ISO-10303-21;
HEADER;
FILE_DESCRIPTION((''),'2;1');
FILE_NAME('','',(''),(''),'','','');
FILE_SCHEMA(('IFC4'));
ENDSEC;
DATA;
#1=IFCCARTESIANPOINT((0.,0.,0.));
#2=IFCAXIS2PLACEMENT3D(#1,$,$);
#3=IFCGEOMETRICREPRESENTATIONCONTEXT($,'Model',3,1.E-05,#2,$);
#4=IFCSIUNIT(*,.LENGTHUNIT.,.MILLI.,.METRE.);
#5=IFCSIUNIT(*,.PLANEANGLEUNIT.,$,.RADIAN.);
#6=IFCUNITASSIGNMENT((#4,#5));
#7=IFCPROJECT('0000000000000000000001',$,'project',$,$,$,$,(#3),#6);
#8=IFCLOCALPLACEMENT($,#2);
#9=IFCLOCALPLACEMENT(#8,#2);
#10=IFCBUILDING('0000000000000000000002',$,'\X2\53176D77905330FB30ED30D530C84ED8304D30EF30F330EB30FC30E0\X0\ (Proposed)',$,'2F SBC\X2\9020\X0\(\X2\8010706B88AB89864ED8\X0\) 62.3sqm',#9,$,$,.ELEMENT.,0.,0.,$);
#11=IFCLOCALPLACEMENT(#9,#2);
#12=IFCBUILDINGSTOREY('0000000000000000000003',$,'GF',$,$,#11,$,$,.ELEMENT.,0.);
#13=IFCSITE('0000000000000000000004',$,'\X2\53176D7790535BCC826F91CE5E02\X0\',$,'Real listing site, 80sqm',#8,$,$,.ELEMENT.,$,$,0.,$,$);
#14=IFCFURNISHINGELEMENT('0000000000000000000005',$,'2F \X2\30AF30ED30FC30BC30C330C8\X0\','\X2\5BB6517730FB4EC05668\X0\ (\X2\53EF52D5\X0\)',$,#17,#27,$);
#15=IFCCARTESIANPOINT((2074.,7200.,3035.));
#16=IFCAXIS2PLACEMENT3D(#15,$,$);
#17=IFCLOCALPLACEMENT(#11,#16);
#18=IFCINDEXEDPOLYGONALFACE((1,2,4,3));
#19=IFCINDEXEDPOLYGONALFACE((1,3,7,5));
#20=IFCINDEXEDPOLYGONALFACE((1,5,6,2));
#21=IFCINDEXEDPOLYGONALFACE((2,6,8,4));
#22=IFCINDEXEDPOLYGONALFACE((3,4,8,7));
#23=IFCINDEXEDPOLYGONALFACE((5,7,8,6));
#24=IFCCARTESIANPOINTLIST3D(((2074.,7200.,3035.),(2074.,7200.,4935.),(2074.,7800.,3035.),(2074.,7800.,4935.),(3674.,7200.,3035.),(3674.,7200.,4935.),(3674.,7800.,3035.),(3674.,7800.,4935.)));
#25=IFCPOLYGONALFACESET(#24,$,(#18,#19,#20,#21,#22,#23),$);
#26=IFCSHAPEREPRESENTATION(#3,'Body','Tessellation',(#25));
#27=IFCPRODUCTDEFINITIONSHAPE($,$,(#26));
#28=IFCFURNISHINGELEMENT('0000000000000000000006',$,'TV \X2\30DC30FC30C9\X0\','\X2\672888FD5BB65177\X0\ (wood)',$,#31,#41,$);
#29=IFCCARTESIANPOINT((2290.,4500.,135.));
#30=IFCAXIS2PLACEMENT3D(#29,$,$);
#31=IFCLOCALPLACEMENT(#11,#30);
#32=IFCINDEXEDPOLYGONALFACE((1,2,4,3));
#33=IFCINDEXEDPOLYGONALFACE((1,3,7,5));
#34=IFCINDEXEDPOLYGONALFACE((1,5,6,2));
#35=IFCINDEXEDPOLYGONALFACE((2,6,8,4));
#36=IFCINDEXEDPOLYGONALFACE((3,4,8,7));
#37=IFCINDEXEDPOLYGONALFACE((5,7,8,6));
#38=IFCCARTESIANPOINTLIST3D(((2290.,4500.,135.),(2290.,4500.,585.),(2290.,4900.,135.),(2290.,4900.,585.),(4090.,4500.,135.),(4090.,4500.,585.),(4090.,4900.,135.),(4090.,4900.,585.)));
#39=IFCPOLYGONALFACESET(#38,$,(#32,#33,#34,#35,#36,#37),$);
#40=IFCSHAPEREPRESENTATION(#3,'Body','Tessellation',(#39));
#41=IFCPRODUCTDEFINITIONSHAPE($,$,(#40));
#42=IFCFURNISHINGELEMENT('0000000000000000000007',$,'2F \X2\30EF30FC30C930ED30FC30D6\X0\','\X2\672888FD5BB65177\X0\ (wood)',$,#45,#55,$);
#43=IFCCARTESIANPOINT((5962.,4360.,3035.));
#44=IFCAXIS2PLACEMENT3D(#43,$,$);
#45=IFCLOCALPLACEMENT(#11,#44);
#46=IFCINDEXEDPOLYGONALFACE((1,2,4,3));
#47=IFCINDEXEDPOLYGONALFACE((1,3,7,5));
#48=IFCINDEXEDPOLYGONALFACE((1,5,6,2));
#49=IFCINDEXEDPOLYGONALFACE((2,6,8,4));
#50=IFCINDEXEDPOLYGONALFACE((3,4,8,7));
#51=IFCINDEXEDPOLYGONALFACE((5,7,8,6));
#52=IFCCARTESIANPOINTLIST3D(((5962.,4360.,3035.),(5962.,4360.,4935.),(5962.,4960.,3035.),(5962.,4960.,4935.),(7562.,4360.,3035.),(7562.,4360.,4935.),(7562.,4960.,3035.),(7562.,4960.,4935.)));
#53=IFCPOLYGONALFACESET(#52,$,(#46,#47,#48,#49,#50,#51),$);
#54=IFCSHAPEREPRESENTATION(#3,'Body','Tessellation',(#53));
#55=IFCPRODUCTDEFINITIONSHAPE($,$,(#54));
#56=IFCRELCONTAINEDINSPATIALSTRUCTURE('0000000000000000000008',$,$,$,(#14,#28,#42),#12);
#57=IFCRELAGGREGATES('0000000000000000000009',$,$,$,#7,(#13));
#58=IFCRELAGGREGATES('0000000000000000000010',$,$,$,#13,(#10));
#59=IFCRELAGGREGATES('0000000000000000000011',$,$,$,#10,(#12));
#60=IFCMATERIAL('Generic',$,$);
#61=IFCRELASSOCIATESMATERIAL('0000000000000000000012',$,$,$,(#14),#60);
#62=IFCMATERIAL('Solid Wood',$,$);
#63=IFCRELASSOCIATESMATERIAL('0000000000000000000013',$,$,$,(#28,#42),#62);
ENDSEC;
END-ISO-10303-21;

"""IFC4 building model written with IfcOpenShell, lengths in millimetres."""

from ifc_helpers import new_model, si_unit, frame, frame_2d, origin, place, context, project, spatial, rectangle, extrude, material, element, save


model = new_model("IFC4")

# Units and contexts
model_context = context("Model", 3, precision=1e-05, world=origin())
ifc_project = project(units=[si_unit("LENGTHUNIT", "METRE", prefix="MILLI"), si_unit("PLANEANGLEUNIT", "RADIAN")], contexts=[model_context])

# Site, building, storey
site_placement = place(None, origin())
site = spatial("IfcSite", under=ifc_project, at=site_placement, Name="北海道富良野市", ObjectType="Real listing site, 80sqm", CompositionType="ELEMENT", RefElevation=0.0)
building_placement = place(site_placement, origin())
building = spatial("IfcBuilding", under=site, at=building_placement, Name="北海道・ロフト付きワンルーム (Proposed)", ObjectType="2F SBC造(耐火被覆付) 62.3sqm", CompositionType="ELEMENT", ElevationOfRefHeight=0.0, ElevationOfTerrain=0.0)
storey_placement = place(building_placement, origin())
storey = spatial("IfcBuildingStorey", under=building, at=storey_placement, Name="GF", CompositionType="ELEMENT", Elevation=0.0)

# Shared definitions
ifc_material_1 = material(Name="Solid Wood")

# Shared definitions
ifc_material_2 = material(Name="Generic")

# Furnishing elements
furnishing_1_placement = place(storey_placement, frame((2074.0, 7200.0, 3035.0)))
element("IfcFurnishingElement", 1, at=furnishing_1_placement, inside=storey, material=ifc_material_2, Name="2F クローゼット", Description="家具・什器 (可動)", context=model_context, shape_type="SweptSolid", body=[
    extrude(rectangle(XDim=1600.0, YDim=600.0, at=frame_2d((800.0, 300.0))), frame((2074.0, 7200.0, 3035.0)), (0.0, 0.0, 1.0), 1900.0),
])
furnishing_2_placement = place(storey_placement, frame((2290.0, 4500.0, 135.0)))
element("IfcFurnishingElement", 2, at=furnishing_2_placement, inside=storey, material=ifc_material_1, Name="TV ボード", Description="木製家具 (wood)", context=model_context, shape_type="SweptSolid", body=[
    extrude(rectangle(XDim=1800.0, YDim=400.0, at=frame_2d((900.0, 200.0))), frame((2290.0, 4500.0, 135.0)), (0.0, 0.0, 1.0), 450.0),
])
furnishing_3_placement = place(storey_placement, frame((5962.0, 4360.0, 3035.0)))
element("IfcFurnishingElement", 3, at=furnishing_3_placement, inside=storey, material=ifc_material_1, Name="2F ワードローブ", Description="木製家具 (wood)", context=model_context, shape_type="SweptSolid", body=[
    extrude(rectangle(XDim=1600.0, YDim=600.0, at=frame_2d((800.0, 300.0))), frame((5962.0, 4360.0, 3035.0)), (0.0, 0.0, 1.0), 1900.0),
])

save(model, "model.ifc")
